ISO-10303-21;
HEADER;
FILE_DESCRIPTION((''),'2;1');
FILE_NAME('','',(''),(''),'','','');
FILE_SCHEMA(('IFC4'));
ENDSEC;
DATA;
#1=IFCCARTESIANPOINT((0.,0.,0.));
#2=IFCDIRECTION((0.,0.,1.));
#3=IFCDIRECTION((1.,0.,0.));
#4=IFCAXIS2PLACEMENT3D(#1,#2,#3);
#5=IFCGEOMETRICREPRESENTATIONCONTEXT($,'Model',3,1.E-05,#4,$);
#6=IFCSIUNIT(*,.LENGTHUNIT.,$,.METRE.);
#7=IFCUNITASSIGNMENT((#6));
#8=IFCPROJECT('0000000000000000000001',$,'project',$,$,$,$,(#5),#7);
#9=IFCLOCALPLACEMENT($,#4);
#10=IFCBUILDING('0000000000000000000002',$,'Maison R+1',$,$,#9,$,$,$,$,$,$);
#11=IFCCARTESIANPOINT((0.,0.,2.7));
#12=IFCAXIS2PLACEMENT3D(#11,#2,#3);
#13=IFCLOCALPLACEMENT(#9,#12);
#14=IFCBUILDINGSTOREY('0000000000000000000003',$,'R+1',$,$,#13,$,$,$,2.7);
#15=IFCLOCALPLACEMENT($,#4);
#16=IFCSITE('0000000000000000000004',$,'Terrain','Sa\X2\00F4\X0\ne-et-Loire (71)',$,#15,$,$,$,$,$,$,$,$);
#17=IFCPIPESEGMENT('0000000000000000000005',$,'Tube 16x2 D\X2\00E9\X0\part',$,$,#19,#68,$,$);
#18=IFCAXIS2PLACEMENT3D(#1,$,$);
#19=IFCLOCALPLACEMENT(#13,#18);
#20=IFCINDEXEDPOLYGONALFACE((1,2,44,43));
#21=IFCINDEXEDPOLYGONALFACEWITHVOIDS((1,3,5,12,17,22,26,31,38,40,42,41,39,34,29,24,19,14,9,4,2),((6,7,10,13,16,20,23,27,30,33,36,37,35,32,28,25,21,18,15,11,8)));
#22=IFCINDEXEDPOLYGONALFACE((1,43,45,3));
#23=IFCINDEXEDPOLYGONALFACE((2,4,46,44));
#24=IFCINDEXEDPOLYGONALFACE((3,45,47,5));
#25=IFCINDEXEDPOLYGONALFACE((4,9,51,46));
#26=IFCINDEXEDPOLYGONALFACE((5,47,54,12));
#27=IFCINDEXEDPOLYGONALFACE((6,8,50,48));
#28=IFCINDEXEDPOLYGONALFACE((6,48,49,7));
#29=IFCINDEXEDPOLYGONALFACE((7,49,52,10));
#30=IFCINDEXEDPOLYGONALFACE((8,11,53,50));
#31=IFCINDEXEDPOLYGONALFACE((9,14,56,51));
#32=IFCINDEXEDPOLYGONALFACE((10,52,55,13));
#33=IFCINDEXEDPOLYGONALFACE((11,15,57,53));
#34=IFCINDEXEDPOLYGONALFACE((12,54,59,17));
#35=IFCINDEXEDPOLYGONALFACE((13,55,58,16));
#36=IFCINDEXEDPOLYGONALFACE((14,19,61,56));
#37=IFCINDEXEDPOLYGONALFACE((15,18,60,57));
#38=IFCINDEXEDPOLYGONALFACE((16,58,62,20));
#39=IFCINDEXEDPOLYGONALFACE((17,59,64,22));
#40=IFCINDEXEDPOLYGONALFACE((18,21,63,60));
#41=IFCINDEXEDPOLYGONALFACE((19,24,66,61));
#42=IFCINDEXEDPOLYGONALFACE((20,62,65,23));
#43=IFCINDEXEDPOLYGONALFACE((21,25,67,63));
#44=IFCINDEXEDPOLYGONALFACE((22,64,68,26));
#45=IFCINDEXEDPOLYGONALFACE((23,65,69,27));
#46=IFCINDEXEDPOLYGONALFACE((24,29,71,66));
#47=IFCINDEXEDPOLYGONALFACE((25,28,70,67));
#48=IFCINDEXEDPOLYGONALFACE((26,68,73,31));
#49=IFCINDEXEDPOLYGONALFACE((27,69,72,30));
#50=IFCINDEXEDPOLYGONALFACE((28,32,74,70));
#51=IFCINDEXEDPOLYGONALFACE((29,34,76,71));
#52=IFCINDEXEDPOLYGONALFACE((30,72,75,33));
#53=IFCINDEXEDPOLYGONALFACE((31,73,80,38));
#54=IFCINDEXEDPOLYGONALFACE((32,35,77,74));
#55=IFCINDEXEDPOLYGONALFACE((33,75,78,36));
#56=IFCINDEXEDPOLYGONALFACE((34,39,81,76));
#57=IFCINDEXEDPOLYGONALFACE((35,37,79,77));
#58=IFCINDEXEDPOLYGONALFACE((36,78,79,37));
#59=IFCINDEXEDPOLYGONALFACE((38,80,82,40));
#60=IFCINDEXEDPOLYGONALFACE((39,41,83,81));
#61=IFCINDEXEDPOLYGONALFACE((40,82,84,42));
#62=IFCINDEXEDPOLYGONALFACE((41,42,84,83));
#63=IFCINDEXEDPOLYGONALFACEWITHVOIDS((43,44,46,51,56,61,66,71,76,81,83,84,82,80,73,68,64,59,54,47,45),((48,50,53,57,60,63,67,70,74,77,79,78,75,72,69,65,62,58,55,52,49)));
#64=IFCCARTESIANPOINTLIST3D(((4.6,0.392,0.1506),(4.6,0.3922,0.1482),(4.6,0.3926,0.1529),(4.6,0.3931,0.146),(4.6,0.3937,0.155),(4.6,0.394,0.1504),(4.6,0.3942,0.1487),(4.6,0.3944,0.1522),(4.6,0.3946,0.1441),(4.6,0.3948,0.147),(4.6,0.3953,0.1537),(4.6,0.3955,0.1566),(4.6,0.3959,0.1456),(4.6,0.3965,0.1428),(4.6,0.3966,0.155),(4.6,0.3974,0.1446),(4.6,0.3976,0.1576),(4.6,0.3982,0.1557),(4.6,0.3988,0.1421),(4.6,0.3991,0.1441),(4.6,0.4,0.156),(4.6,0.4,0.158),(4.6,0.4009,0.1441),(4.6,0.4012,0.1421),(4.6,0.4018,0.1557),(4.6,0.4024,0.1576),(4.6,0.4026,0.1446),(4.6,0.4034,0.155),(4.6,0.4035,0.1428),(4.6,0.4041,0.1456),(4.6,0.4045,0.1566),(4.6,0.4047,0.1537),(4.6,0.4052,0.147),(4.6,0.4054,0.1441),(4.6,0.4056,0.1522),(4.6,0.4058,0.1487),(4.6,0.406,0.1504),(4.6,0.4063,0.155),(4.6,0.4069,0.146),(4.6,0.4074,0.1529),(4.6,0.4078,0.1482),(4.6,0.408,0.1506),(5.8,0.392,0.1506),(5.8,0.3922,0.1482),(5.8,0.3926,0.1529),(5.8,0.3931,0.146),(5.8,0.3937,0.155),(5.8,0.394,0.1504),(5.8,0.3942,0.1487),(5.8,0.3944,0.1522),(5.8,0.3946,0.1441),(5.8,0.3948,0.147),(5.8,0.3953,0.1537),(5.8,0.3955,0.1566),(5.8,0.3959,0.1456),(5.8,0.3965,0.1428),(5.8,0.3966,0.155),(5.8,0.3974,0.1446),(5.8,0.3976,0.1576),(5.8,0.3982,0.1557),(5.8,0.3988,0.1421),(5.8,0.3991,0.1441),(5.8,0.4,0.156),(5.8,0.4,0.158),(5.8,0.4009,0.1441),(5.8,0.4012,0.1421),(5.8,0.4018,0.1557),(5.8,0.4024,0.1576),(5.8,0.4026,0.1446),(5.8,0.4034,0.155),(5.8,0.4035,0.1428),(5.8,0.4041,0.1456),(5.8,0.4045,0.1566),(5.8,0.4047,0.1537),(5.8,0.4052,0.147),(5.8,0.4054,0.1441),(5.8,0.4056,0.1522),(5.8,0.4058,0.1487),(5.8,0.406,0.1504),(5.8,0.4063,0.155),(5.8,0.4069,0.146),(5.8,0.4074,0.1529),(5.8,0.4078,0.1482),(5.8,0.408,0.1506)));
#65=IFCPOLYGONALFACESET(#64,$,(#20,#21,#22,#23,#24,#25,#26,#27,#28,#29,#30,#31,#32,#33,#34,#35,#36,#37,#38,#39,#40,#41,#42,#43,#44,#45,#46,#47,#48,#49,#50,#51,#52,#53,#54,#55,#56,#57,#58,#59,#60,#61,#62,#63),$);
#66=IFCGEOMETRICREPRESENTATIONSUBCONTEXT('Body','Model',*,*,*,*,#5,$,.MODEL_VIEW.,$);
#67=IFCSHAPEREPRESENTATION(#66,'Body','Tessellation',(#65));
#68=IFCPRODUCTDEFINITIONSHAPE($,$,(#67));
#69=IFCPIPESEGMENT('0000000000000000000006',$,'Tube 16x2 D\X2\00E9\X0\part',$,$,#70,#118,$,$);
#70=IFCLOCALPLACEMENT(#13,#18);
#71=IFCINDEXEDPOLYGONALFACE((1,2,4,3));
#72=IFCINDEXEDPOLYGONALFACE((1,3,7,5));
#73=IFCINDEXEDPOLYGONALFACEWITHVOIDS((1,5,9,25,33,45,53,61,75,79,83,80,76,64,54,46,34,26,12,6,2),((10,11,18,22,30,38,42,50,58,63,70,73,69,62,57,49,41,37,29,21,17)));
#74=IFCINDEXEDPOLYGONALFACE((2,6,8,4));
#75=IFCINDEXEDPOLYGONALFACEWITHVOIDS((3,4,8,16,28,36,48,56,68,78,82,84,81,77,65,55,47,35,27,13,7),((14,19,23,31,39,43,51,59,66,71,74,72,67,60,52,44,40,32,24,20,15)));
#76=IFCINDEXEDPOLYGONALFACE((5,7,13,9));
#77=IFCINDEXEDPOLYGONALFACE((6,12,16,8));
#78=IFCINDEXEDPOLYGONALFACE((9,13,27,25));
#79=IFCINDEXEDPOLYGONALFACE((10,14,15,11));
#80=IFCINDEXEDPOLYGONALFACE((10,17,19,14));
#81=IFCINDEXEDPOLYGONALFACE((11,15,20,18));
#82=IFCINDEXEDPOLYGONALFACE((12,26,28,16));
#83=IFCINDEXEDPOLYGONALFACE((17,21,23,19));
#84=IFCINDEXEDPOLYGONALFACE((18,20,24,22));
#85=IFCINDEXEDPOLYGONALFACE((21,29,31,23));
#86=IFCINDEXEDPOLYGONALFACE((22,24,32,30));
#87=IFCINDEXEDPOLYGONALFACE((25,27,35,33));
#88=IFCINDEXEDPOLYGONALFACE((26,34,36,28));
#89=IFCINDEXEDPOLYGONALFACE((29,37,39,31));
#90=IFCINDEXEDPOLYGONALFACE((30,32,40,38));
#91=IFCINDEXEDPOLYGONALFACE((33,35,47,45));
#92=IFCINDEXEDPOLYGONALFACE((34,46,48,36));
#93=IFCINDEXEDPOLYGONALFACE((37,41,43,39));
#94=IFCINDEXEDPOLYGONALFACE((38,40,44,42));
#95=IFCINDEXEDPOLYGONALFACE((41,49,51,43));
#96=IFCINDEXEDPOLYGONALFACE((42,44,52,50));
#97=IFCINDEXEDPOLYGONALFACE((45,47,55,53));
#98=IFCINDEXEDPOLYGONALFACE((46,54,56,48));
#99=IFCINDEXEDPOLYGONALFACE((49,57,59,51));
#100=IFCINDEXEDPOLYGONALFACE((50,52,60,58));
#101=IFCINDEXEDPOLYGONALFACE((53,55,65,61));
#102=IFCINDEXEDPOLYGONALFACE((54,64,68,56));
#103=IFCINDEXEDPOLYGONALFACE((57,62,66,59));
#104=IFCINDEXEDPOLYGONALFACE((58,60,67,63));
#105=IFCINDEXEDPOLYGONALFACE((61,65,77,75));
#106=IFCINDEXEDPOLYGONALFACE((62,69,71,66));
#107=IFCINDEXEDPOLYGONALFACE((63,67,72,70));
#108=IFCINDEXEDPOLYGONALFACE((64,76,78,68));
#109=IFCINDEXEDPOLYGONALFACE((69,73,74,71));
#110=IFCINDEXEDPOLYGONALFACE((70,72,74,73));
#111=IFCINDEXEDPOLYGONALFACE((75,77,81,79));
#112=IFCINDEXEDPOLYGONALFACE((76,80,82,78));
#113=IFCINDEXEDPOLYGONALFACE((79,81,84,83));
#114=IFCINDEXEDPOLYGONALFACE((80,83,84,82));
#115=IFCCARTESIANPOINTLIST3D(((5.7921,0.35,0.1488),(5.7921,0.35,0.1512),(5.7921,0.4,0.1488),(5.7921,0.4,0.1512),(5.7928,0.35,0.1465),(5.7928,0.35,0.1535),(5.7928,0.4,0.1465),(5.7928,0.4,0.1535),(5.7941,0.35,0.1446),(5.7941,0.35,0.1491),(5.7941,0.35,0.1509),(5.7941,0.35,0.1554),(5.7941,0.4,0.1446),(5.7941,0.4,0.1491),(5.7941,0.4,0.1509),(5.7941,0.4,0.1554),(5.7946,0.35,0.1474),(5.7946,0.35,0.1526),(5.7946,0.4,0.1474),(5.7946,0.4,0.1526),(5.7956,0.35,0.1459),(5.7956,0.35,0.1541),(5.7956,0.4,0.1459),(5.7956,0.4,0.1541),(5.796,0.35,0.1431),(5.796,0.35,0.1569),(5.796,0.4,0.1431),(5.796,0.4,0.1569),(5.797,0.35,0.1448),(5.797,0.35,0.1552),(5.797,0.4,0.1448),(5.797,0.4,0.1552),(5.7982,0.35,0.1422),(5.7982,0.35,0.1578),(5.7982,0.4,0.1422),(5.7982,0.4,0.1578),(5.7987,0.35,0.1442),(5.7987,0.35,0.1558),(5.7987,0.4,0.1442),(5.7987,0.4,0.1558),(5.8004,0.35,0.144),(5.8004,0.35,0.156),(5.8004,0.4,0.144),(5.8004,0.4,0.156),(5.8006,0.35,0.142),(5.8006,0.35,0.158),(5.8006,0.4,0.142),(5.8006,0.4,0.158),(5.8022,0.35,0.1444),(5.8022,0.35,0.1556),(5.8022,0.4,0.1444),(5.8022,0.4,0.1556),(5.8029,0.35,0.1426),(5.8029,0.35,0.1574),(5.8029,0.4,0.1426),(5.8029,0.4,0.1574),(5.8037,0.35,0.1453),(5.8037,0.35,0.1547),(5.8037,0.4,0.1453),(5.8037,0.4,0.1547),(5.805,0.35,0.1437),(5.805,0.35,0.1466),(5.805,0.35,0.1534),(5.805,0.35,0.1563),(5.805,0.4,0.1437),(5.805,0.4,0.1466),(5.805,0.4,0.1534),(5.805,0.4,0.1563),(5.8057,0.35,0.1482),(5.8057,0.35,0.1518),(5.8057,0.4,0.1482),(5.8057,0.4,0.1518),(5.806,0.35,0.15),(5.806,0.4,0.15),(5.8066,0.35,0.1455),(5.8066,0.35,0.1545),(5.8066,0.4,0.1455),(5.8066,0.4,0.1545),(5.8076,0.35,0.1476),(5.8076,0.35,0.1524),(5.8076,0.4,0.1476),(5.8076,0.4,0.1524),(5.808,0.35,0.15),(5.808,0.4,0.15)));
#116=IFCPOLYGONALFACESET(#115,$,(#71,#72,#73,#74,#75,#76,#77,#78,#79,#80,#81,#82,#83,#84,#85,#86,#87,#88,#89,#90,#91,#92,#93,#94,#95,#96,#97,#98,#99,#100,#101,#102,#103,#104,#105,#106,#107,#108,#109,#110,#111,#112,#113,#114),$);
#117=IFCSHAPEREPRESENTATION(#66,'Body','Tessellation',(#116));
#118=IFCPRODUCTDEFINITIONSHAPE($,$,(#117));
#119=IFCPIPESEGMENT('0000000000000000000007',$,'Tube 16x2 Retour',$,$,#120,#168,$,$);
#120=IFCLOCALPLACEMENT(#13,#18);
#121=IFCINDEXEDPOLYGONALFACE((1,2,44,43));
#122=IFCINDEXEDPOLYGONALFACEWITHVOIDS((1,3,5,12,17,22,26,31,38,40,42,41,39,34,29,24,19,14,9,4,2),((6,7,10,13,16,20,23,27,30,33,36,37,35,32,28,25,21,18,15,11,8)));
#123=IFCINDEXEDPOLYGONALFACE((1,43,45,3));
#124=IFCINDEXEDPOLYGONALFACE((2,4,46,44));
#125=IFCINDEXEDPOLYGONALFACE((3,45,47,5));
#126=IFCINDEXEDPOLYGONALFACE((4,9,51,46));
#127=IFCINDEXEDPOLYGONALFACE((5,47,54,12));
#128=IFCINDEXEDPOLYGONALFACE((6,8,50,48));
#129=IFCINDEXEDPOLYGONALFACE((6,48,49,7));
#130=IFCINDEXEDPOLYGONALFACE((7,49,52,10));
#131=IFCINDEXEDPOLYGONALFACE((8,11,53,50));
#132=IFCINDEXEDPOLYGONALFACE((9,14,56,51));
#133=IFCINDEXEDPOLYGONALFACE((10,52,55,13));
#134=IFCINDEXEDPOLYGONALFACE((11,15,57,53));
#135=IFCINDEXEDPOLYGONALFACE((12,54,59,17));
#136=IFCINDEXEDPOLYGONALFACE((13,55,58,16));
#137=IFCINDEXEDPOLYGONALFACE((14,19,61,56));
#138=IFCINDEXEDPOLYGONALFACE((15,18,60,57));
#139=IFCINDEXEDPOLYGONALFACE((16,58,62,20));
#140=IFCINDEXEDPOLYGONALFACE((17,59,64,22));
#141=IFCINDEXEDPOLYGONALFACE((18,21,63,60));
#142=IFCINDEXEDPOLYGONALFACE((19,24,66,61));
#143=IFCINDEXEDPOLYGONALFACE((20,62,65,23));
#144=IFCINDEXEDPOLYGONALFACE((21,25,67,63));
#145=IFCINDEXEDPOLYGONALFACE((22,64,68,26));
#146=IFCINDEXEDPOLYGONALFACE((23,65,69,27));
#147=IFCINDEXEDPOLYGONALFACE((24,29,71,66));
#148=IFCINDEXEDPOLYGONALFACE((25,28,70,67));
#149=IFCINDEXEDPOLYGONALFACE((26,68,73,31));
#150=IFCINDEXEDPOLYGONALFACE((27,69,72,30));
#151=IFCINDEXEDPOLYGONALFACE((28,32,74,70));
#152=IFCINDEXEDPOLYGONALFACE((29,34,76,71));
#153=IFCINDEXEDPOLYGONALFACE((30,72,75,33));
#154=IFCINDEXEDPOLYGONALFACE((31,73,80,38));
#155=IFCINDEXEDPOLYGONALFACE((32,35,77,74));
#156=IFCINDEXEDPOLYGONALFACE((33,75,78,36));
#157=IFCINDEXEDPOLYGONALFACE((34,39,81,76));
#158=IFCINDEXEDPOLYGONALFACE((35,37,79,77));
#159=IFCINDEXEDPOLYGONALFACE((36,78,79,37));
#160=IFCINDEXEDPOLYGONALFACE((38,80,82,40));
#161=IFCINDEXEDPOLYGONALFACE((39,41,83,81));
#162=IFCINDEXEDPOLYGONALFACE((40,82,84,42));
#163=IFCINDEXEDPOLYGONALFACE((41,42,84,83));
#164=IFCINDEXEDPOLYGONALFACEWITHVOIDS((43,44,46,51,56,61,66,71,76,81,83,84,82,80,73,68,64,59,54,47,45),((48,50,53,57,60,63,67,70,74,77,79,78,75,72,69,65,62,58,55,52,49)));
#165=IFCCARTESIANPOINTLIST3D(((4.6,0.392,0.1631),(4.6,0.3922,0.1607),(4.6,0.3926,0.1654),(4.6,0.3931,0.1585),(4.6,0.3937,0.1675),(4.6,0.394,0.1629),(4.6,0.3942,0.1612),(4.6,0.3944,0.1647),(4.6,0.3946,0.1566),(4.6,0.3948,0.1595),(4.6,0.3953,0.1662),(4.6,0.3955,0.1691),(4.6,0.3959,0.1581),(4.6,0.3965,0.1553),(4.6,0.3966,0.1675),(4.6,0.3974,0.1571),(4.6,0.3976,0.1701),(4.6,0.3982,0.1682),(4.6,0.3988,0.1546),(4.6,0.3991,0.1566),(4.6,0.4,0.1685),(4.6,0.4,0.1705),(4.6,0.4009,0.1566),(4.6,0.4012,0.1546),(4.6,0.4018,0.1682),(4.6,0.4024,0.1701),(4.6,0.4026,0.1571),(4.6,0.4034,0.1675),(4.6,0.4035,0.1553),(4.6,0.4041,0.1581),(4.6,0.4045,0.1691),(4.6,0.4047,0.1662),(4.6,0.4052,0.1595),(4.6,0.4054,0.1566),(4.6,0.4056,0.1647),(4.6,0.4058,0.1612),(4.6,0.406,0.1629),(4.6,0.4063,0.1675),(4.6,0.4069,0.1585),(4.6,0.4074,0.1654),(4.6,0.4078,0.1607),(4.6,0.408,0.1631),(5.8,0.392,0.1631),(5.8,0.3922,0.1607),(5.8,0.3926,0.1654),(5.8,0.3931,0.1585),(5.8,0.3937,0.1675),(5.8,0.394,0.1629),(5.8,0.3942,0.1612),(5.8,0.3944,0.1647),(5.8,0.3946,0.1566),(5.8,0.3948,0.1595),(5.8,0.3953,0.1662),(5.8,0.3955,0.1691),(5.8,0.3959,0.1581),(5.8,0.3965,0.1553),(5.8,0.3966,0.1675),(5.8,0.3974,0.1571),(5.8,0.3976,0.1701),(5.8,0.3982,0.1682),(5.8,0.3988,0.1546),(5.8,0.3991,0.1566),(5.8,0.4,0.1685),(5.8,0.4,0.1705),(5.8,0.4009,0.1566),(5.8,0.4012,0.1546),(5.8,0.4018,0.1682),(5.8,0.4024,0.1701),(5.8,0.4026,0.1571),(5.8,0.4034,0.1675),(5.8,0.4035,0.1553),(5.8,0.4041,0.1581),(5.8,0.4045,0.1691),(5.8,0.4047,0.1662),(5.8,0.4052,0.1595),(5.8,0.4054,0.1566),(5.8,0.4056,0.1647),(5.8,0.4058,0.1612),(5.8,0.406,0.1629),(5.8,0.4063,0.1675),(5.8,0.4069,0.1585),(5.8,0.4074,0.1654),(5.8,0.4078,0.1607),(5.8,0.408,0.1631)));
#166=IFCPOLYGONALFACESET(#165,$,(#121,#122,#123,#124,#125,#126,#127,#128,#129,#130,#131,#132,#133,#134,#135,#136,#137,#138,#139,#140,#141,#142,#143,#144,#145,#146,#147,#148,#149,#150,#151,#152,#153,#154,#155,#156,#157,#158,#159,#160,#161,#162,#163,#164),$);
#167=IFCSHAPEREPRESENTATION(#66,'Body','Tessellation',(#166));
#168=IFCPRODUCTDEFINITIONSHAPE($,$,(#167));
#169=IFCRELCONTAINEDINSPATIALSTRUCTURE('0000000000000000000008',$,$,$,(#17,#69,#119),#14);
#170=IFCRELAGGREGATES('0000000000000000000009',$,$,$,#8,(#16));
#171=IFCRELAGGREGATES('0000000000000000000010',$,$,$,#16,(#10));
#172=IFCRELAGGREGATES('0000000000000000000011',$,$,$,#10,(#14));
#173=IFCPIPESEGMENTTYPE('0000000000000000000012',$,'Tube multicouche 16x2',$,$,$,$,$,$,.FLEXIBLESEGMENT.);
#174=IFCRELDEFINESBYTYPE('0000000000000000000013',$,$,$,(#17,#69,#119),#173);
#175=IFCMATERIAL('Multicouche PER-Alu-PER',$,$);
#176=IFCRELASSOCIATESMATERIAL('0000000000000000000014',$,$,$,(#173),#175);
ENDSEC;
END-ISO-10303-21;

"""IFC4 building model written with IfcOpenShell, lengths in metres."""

from ifc_helpers import new_model, si_unit, frame, origin_with_axes, place, context, subcontext, project, spatial, hollow_circle, extrude, material, type_object, element, save


model = new_model("IFC4")

# Units and contexts
model_context = context("Model", 3, precision=1e-05, world=origin_with_axes())
body_context = subcontext(model_context, "Body", "Model", "MODEL_VIEW")
ifc_project = project(units=[si_unit("LENGTHUNIT", "METRE")], contexts=[model_context])

# Site, building, storey
site_placement = place(None, origin_with_axes())
site = spatial("IfcSite", under=ifc_project, at=site_placement, Name="Terrain", Description="Saône-et-Loire (71)")
building_placement = place(None, origin_with_axes())
building = spatial("IfcBuilding", under=site, at=building_placement, Name="Maison R+1")
storey_placement = place(building_placement, frame((0.0, 0.0, 2.7), z_axis=(0.0, 0.0, 1.0), x_axis=(1.0, 0.0, 0.0)))
storey = spatial("IfcBuildingStorey", under=building, at=storey_placement, Name="R+1", Elevation=2.7)

# Pipe segments
ifc_material_1 = material(Name="Multicouche PER-Alu-PER")
pipe_segment_type = type_object("IfcPipeSegmentType", Name="Tube multicouche 16x2", PredefinedType="FLEXIBLESEGMENT", material=ifc_material_1)
pipe_segment_1_placement = place(storey_placement, frame((4.6, 0.4, 0.15), z_axis=(1.0, 0.0, 0.0), x_axis=(0.0, 0.0, 1.0)))
element("IfcPipeSegment", 1, at=pipe_segment_1_placement, inside=storey, type_object=pipe_segment_type, Name="Tube 16x2 Départ", context=body_context, shape_type="SweptSolid", body=[
    extrude(hollow_circle(Radius=0.008, WallThickness=0.002), origin_with_axes(), (0.0, 0.0, 1.0), 1.2),
])
pipe_segment_2_placement = place(storey_placement, frame((5.8, 0.4, 0.15), z_axis=(0.0, -1.0, 0.0), x_axis=(1.0, 0.0, 0.0)))
element("IfcPipeSegment", 2, at=pipe_segment_2_placement, inside=storey, type_object=pipe_segment_type, Name="Tube 16x2 Départ", context=body_context, shape_type="SweptSolid", body=[
    extrude(hollow_circle(Radius=0.008, WallThickness=0.002), origin_with_axes(), (0.0, 0.0, 1.0), 0.05),
])
pipe_segment_3_placement = place(storey_placement, frame((4.6, 0.4, 0.1625), z_axis=(1.0, 0.0, 0.0), x_axis=(0.0, 0.0, 1.0)))
element("IfcPipeSegment", 3, at=pipe_segment_3_placement, inside=storey, type_object=pipe_segment_type, Name="Tube 16x2 Retour", context=body_context, shape_type="SweptSolid", body=[
    extrude(hollow_circle(Radius=0.008, WallThickness=0.002), origin_with_axes(), (0.0, 0.0, 1.0), 1.2),
])

save(model, "model.ifc")
